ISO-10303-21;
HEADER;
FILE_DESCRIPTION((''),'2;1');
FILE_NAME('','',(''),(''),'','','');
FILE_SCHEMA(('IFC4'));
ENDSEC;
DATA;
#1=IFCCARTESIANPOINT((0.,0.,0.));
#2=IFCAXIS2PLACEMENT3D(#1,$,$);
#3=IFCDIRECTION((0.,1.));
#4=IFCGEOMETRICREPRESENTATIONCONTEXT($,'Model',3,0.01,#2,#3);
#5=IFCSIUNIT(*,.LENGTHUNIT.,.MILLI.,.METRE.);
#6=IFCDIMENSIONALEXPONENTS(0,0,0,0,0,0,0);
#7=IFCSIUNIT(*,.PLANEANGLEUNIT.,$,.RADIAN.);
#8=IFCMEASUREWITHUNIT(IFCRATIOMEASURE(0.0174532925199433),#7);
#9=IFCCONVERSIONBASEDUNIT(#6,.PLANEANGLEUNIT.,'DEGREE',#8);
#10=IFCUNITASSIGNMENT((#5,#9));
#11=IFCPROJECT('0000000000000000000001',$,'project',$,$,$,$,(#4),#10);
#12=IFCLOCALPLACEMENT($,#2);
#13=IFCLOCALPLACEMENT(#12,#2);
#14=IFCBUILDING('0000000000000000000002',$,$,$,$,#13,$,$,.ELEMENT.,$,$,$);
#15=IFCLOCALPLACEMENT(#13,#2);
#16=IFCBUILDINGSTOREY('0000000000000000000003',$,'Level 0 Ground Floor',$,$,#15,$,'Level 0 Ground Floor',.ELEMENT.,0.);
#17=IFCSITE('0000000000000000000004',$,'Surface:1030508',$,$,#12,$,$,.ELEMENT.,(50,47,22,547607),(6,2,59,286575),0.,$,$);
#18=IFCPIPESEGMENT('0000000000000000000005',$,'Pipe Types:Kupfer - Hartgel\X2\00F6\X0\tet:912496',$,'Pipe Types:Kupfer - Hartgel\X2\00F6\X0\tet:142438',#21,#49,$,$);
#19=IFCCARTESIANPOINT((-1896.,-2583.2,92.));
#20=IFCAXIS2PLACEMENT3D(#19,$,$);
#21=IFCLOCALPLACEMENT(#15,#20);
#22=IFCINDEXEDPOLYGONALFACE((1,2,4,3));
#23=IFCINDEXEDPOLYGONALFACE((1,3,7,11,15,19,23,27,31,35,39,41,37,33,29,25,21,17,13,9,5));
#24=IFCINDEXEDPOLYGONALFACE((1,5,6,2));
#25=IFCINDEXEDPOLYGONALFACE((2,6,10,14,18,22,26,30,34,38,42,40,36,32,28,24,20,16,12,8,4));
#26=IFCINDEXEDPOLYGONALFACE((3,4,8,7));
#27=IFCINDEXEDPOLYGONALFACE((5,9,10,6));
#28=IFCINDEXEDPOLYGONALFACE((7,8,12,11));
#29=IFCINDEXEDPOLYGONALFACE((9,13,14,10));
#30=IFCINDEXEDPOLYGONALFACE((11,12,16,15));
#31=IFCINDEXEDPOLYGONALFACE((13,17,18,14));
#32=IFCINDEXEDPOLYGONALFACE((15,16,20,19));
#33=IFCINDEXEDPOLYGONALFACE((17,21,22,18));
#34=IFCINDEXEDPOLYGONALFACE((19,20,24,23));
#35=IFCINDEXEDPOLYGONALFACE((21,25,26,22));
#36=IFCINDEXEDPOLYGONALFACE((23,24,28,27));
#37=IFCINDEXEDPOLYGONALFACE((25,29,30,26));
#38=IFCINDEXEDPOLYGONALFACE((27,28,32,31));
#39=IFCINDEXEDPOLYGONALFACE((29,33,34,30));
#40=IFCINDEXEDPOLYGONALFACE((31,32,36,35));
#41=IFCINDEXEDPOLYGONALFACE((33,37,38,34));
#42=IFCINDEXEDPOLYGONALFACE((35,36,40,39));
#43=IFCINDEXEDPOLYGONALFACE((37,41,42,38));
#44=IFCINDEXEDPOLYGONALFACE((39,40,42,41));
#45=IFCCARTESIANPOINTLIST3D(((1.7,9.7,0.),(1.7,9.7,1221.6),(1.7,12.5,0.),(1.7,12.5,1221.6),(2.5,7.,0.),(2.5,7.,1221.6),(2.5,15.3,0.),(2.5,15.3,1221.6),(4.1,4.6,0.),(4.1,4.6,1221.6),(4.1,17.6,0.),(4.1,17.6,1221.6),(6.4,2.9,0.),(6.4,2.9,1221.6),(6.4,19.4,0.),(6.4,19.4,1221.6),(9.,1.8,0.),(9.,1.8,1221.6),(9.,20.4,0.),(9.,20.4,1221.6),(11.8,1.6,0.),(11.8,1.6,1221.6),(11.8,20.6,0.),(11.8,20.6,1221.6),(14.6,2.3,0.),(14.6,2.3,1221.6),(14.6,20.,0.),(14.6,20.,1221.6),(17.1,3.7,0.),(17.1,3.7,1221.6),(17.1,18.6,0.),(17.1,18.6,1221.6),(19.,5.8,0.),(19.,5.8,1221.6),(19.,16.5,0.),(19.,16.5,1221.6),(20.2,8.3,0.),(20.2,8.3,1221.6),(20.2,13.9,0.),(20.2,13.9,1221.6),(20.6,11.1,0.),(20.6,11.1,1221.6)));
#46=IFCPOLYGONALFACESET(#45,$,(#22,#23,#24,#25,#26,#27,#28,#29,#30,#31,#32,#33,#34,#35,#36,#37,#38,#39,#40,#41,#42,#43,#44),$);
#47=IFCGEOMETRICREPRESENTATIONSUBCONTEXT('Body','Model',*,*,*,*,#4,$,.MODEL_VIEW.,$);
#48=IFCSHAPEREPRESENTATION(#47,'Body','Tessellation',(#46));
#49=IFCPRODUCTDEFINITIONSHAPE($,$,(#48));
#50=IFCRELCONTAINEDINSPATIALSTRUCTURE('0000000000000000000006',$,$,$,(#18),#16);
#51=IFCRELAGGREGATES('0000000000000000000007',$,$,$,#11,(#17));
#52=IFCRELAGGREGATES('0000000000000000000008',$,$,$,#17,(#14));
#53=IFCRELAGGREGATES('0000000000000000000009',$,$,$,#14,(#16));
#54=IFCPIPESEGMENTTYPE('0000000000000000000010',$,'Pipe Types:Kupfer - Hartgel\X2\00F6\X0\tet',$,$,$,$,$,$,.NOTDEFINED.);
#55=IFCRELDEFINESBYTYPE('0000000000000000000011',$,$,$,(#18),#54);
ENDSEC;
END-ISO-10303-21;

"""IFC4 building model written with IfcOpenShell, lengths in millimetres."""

from ifc_helpers import new_model, entity, si_unit, converted_unit, direction, frame, origin, origin_2d_with_axis, place, context, subcontext, project, spatial, circle, extrude, type_object, element, save


model = new_model("IFC4")

# Units and contexts
model_context = context("Model", 3, precision=0.01, world=origin(), true_north=direction((0.0, 1.0)))
body_context = subcontext(model_context, "Body", "Model", "MODEL_VIEW")
ifc_project = project(units=[si_unit("LENGTHUNIT", "METRE", prefix="MILLI"), converted_unit("PLANEANGLEUNIT", "DEGREE", entity("IfcRatioMeasure", 0.0174532925199433), si_unit("PLANEANGLEUNIT", "RADIAN"), dimensions=[0, 0, 0, 0, 0, 0, 0])], contexts=[model_context])

# Site, building, storey
site_placement = place(None, origin())
site = spatial("IfcSite", under=ifc_project, at=site_placement, Name="Surface:1030508", CompositionType="ELEMENT", RefLatitude=(50, 47, 22, 547607), RefLongitude=(6, 2, 59, 286575), RefElevation=0.0)
building_placement = place(site_placement, origin())
building = spatial("IfcBuilding", under=site, at=building_placement, CompositionType="ELEMENT")
storey_placement = place(building_placement, origin())
storey = spatial("IfcBuildingStorey", under=building, at=storey_placement, Name="Level 0 Ground Floor", LongName="Level 0 Ground Floor", CompositionType="ELEMENT", Elevation=0.0)

# Pipe segment
pipe_segment_type = type_object("IfcPipeSegmentType", Name="Pipe Types:Kupfer - Hartgelötet", PredefinedType="NOTDEFINED")
pipe_segment_1_placement = place(storey_placement, frame((-1896.0, -2583.2, 92.0)))
element("IfcPipeSegment", 1, at=pipe_segment_1_placement, inside=storey, type_object=pipe_segment_type, Name="Pipe Types:Kupfer - Hartgelötet:912496", ObjectType="Pipe Types:Kupfer - Hartgelötet:142438", context=body_context, shape_type="SweptSolid", body=[
    extrude(circle(Radius=9.5, at=origin_2d_with_axis()), frame((11.1, 11.1, 0.0)), (0.0, 0.0, 1.0), 1221.6),
])

save(model, "model.ifc")
